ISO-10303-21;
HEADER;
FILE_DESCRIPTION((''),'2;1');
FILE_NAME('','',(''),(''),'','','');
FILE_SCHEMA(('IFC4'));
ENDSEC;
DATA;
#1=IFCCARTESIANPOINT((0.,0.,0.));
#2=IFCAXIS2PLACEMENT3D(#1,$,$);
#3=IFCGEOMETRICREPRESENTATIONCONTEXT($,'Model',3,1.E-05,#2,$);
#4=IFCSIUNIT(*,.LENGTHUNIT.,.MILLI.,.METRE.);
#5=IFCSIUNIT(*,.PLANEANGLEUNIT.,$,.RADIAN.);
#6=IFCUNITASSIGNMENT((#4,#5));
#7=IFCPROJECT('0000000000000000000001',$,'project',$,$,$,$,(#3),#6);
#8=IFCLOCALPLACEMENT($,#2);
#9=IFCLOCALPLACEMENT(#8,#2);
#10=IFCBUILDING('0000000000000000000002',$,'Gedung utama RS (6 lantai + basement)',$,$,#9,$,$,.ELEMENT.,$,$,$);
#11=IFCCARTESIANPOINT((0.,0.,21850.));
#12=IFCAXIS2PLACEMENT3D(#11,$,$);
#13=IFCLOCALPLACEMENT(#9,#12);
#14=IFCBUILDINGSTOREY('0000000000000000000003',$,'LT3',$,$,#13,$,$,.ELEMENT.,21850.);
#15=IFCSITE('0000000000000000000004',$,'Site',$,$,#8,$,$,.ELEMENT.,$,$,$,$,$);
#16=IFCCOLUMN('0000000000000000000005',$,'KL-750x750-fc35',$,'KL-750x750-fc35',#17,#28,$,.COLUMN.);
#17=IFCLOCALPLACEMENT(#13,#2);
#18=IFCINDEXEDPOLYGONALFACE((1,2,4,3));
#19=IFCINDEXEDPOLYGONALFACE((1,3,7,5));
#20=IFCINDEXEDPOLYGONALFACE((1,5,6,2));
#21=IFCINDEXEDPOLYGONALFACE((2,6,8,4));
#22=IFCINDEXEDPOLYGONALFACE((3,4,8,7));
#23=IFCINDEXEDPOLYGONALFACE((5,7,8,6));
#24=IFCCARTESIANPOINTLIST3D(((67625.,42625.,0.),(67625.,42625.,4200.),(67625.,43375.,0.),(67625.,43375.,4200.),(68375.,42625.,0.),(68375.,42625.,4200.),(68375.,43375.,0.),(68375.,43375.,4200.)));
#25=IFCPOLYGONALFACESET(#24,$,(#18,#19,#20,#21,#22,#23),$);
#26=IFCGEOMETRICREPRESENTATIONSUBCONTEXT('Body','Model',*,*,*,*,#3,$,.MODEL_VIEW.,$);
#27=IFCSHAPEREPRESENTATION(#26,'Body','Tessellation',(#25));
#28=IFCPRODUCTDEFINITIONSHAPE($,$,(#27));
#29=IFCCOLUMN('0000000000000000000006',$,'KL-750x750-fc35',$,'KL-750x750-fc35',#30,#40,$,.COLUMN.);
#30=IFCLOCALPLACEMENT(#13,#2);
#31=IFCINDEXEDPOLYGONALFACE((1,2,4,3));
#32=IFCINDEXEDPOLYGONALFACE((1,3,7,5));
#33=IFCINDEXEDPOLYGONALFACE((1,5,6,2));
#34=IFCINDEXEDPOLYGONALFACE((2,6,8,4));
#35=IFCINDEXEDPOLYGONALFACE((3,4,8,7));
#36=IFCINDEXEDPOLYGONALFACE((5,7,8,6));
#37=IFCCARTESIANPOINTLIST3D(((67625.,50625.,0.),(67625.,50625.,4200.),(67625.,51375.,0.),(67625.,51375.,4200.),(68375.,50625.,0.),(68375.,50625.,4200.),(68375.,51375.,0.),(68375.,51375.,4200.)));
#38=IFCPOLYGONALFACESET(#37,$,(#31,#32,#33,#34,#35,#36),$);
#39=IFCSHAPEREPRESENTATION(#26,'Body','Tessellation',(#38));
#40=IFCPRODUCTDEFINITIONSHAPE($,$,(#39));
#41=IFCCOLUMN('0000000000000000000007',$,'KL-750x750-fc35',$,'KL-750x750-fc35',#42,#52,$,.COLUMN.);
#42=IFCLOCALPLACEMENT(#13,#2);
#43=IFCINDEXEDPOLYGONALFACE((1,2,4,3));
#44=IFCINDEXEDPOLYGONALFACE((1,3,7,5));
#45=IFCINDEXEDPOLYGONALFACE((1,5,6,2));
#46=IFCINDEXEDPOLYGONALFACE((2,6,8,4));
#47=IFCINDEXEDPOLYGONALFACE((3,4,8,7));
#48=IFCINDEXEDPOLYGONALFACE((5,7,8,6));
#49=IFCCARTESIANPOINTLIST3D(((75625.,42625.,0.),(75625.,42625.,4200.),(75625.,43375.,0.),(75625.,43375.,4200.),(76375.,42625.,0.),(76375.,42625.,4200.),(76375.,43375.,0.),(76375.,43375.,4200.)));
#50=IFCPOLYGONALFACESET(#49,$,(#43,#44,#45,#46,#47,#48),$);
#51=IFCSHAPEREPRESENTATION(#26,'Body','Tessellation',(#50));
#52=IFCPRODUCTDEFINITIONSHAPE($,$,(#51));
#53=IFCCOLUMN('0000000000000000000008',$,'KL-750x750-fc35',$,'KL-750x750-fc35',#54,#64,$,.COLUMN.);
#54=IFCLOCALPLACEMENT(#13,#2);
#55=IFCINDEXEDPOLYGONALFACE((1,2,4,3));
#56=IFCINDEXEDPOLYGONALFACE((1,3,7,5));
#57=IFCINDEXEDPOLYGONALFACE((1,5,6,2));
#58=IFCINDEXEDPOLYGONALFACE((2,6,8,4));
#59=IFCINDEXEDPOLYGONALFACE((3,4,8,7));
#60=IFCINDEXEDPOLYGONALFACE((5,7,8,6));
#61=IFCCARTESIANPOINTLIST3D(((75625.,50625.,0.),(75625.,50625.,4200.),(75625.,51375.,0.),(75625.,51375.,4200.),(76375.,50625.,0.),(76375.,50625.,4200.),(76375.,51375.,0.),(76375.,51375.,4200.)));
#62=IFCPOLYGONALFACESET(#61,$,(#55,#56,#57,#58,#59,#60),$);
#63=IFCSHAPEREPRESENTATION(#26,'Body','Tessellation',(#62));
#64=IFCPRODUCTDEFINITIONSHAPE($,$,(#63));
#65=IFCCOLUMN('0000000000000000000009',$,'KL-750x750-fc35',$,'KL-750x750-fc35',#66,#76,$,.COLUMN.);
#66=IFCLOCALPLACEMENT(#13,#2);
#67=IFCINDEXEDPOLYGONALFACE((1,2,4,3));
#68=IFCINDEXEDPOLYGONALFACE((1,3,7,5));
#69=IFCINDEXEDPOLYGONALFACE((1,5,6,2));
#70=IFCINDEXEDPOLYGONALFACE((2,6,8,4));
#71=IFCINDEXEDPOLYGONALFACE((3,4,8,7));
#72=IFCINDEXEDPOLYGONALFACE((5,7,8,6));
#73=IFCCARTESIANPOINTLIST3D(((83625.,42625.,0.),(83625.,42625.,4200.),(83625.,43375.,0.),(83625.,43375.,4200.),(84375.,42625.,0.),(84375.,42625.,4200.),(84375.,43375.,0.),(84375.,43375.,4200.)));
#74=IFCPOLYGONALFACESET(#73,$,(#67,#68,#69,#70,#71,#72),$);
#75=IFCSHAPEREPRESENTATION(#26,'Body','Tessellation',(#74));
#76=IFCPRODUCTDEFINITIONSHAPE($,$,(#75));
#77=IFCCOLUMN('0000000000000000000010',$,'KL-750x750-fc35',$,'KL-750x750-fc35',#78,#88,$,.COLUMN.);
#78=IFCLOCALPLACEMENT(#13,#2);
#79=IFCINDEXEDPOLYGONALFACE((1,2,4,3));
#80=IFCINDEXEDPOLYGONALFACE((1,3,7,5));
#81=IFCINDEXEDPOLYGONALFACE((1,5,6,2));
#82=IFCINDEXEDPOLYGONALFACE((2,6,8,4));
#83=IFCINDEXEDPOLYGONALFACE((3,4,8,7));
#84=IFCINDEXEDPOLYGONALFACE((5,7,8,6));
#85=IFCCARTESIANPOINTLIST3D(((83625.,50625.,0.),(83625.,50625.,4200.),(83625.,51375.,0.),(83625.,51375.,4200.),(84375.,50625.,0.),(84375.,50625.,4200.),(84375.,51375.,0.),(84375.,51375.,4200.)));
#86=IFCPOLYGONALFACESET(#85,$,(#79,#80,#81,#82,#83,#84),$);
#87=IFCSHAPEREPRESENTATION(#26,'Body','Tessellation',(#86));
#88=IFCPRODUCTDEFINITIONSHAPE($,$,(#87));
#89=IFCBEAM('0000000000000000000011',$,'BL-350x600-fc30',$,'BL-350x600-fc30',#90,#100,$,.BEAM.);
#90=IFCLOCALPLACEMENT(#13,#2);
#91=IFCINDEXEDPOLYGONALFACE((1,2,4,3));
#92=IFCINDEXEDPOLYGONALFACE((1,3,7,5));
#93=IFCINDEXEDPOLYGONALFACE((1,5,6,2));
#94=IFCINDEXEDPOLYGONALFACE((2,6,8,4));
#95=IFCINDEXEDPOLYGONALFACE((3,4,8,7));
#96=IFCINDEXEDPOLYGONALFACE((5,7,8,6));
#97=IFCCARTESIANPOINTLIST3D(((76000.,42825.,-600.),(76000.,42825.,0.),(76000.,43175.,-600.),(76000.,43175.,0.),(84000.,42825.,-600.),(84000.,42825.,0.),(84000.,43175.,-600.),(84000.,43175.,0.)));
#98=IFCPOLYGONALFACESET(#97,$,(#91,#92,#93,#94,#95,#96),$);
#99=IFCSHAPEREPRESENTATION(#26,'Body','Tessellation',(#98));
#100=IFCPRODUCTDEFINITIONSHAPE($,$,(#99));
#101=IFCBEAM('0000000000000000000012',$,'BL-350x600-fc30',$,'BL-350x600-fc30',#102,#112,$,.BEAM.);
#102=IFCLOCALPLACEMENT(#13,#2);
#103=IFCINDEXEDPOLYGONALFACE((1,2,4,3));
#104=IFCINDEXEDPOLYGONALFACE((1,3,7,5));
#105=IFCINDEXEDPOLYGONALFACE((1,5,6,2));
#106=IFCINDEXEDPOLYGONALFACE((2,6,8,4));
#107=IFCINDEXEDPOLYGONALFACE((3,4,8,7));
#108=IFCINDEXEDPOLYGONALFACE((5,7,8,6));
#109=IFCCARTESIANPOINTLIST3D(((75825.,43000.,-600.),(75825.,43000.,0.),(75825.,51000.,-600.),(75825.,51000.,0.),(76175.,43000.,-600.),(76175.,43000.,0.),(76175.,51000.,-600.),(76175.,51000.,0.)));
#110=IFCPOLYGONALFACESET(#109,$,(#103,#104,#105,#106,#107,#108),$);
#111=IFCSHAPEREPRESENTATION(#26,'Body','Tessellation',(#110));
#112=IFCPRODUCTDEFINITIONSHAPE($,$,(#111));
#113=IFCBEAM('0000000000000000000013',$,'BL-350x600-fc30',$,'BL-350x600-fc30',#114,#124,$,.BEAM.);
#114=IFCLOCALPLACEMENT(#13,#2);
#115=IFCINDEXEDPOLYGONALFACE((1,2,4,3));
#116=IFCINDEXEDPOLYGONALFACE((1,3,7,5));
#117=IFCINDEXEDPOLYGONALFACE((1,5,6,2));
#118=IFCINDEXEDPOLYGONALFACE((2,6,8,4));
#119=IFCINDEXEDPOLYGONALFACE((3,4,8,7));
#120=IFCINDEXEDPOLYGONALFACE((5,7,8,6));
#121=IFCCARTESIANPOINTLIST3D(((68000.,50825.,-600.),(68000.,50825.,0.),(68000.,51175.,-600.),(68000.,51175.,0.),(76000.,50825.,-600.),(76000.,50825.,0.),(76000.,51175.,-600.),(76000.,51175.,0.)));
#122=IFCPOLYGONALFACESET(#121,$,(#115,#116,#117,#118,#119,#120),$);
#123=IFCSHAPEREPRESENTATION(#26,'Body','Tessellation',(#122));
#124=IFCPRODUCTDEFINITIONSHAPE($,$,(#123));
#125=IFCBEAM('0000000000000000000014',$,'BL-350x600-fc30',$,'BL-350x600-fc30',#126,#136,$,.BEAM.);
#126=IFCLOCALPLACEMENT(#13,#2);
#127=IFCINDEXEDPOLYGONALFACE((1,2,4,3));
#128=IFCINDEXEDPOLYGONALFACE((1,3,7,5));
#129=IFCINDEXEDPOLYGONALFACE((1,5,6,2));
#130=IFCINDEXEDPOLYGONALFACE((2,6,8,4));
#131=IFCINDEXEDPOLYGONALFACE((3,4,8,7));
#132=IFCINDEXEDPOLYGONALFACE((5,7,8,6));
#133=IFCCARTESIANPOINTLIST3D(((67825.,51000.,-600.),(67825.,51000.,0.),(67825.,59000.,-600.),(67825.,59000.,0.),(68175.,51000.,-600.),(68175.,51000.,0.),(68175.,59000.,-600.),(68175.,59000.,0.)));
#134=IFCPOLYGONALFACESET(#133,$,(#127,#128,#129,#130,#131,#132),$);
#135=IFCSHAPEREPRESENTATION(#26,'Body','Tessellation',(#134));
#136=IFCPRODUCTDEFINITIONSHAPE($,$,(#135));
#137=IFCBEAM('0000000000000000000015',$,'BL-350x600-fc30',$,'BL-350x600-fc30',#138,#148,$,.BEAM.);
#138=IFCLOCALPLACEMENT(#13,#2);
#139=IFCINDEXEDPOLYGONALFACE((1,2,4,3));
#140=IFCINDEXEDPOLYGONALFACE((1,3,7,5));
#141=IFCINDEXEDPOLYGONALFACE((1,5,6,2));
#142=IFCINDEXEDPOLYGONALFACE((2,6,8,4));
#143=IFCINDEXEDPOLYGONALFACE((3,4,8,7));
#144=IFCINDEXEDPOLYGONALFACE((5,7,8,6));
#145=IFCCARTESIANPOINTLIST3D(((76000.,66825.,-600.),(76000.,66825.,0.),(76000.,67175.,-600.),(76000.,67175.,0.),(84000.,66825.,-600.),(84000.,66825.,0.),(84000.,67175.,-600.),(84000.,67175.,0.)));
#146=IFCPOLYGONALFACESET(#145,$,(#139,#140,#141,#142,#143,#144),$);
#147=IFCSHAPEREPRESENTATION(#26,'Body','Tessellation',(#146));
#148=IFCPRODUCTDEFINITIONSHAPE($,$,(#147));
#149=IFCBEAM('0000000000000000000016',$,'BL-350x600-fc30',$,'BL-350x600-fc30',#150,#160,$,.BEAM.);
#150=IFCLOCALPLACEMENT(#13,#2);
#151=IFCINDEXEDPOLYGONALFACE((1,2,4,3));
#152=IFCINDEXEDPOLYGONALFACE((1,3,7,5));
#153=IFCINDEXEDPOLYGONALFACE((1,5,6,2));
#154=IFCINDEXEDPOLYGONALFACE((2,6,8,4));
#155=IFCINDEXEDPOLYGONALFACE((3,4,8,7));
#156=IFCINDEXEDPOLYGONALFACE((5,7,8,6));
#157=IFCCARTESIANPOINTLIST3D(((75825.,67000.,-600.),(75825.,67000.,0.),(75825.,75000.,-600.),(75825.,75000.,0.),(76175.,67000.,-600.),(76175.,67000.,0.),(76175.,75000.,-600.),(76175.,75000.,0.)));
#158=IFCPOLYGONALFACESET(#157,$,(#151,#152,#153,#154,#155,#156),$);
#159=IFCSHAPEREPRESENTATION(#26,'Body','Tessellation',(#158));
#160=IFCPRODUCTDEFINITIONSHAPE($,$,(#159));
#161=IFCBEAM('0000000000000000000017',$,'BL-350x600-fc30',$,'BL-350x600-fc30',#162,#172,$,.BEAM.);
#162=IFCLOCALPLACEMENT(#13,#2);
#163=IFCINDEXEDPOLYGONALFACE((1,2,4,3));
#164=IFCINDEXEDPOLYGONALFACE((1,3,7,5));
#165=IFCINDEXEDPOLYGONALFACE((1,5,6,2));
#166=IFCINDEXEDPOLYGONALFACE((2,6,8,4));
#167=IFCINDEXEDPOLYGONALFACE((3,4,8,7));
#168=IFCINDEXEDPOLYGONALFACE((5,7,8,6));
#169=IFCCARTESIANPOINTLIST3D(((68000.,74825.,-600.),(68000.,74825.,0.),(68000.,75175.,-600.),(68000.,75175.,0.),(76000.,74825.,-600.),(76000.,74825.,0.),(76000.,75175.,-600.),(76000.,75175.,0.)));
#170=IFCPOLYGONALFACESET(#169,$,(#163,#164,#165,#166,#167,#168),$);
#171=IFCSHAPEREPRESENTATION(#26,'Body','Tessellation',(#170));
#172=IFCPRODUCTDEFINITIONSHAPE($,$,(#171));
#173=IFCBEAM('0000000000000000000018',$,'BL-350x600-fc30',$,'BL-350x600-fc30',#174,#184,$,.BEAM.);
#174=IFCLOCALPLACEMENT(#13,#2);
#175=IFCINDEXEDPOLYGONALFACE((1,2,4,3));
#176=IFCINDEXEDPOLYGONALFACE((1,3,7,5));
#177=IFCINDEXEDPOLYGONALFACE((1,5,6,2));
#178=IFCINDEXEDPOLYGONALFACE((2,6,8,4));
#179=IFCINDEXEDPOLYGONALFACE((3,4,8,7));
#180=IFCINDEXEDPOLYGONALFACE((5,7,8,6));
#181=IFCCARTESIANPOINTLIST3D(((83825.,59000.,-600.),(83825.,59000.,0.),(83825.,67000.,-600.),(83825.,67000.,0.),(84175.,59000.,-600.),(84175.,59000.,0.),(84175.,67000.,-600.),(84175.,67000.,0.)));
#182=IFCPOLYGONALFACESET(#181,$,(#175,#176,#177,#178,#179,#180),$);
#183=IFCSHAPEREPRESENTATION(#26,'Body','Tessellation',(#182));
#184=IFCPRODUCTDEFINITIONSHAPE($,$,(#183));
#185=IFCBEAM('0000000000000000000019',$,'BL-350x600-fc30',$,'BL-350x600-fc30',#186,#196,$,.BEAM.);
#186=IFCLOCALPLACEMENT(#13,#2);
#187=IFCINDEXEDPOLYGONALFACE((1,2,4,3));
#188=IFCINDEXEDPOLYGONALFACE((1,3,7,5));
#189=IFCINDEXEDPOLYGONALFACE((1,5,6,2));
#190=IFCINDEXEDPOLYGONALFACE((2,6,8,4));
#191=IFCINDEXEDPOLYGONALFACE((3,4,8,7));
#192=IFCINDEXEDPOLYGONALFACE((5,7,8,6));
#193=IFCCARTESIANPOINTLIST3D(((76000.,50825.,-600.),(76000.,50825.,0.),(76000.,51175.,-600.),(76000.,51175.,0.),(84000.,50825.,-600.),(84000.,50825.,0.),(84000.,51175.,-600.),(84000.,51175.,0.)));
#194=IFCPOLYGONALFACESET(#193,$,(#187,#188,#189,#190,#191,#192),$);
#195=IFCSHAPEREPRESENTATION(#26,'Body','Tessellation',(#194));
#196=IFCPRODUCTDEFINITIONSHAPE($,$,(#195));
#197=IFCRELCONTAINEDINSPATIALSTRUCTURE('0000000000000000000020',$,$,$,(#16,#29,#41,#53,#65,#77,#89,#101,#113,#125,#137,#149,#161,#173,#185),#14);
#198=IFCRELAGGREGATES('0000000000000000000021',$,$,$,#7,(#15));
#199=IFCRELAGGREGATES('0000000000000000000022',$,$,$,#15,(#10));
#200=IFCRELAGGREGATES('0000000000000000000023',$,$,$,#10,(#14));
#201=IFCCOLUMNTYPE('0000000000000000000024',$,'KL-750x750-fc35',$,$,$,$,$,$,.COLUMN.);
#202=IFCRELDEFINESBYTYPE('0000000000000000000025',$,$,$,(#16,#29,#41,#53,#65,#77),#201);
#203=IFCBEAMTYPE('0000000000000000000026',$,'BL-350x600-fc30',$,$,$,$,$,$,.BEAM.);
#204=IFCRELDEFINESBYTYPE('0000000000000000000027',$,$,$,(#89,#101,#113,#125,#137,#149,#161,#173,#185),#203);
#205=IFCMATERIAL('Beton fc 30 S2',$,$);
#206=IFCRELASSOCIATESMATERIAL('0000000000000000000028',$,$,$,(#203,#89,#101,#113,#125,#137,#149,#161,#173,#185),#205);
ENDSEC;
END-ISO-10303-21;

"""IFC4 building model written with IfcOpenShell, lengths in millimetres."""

from ifc_helpers import new_model, si_unit, frame, origin, origin_2d, place, context, subcontext, project, spatial, rectangle, extrude, material, material_profile, profile_set, profile_usage, type_object, element, save


model = new_model("IFC4")

# Units and contexts
model_context = context("Model", 3, precision=1e-05, world=origin())
body_context = subcontext(model_context, "Body", "Model", "MODEL_VIEW")
ifc_project = project(units=[si_unit("LENGTHUNIT", "METRE", prefix="MILLI"), si_unit("PLANEANGLEUNIT", "RADIAN")], contexts=[model_context])

# Site, building, storey
site_placement = place(None, origin())
site = spatial("IfcSite", under=ifc_project, at=site_placement, Name="Site", CompositionType="ELEMENT")
building_placement = place(site_placement, origin())
building = spatial("IfcBuilding", under=site, at=building_placement, Name="Gedung utama RS (6 lantai + basement)", CompositionType="ELEMENT")
storey_placement = place(building_placement, frame((0.0, 0.0, 21850.0)))
storey = spatial("IfcBuildingStorey", under=building, at=storey_placement, Name="LT3", CompositionType="ELEMENT", Elevation=21850.0)

# Columns
ifc_material_profile_1 = material_profile(None, rectangle(XDim=750.0, YDim=750.0, at=origin_2d()), Name="KL-750x750-fc35")
ifc_profile_set_1 = profile_set([ifc_material_profile_1], Name="KL-750x750-fc35")
ifc_profile_usage_1 = profile_usage(ifc_profile_set_1, cardinal=5)
column_type = type_object("IfcColumnType", Name="KL-750x750-fc35", PredefinedType="COLUMN", material=ifc_profile_set_1)
for number, where, z_axis, x_axis, name in (
    (1, (68000.0, 43000.0, 0.0), (0.0, 0.0, 1.0), (1.0, 0.0, 0.0), "KL-750x750-fc35"),
    (2, (68000.0, 51000.0, 0.0), (0.0, 0.0, 1.0), (1.0, 0.0, 0.0), "KL-750x750-fc35"),
    (3, (76000.0, 43000.0, 0.0), (0.0, 0.0, 1.0), (1.0, 0.0, 0.0), "KL-750x750-fc35"),
    (4, (76000.0, 51000.0, 0.0), (0.0, 0.0, 1.0), (1.0, 0.0, 0.0), "KL-750x750-fc35"),
    (5, (84000.0, 43000.0, 0.0), (0.0, 0.0, 1.0), (1.0, 0.0, 0.0), "KL-750x750-fc35"),
    (6, (84000.0, 51000.0, 0.0), (0.0, 0.0, 1.0), (1.0, 0.0, 0.0), "KL-750x750-fc35"),
):
    element("IfcColumn", number, at=place(storey_placement, frame(where, z_axis=z_axis, x_axis=x_axis)), inside=storey, type_object=column_type, material=ifc_profile_usage_1, Name=name, ObjectType="KL-750x750-fc35", PredefinedType="COLUMN", context=body_context, shape_type="SweptSolid", body=[
        extrude(rectangle(XDim=750.0, YDim=750.0, at=origin_2d()), origin(), (0.0, 0.0, 1.0), 4200.0),
    ])

# Beams
ifc_material = material(Name="Beton fc 30 S2")
ifc_material_profile_2 = material_profile(ifc_material, rectangle(XDim=350.0, YDim=600.0, at=origin_2d()), Name="BL-350x600-fc30")
ifc_profile_set_2 = profile_set([ifc_material_profile_2], Name="BL-350x600-fc30")
ifc_profile_usage_2 = profile_usage(ifc_profile_set_2, cardinal=8)
beam_type_1 = type_object("IfcBeamType", Name="BL-350x600-fc30", PredefinedType="BEAM", material=ifc_profile_set_2)
beam_1_placement = place(storey_placement, frame((76000.0, 43000.0, -300.0)))
element("IfcBeam", 7, at=beam_1_placement, inside=storey, type_object=beam_type_1, material=ifc_profile_usage_2, Name="BL-350x600-fc30", ObjectType="BL-350x600-fc30", PredefinedType="BEAM", context=body_context, shape_type="SweptSolid", body=[
    extrude(rectangle(XDim=350.0, YDim=600.0, at=origin_2d()), frame((0.0, 0.0, 0.0), z_axis=(1.0, 0.0, 0.0), x_axis=(0.0, 1.0, 0.0)), (0.0, 0.0, 1.0), 8000.0),
])
beam_2_placement = place(storey_placement, frame((76000.0, 43000.0, -300.0)))
element("IfcBeam", 8, at=beam_2_placement, inside=storey, type_object=beam_type_1, material=ifc_profile_usage_2, Name="BL-350x600-fc30", ObjectType="BL-350x600-fc30", PredefinedType="BEAM", context=body_context, shape_type="SweptSolid", body=[
    extrude(rectangle(XDim=350.0, YDim=600.0, at=origin_2d()), frame((0.0, 0.0, 0.0), z_axis=(0.0, 1.0, 0.0), x_axis=(-1.0, 0.0, 0.0)), (0.0, 0.0, 1.0), 8000.0),
])
beam_3_placement = place(storey_placement, frame((68000.0, 51000.0, -300.0)))
element("IfcBeam", 9, at=beam_3_placement, inside=storey, type_object=beam_type_1, material=ifc_profile_usage_2, Name="BL-350x600-fc30", ObjectType="BL-350x600-fc30", PredefinedType="BEAM", context=body_context, shape_type="SweptSolid", body=[
    extrude(rectangle(XDim=350.0, YDim=600.0, at=origin_2d()), frame((0.0, 0.0, 0.0), z_axis=(1.0, 0.0, 0.0), x_axis=(0.0, 1.0, 0.0)), (0.0, 0.0, 1.0), 8000.0),
])
beam_4_placement = place(storey_placement, frame((68000.0, 51000.0, -300.0)))
element("IfcBeam", 10, at=beam_4_placement, inside=storey, type_object=beam_type_1, material=ifc_profile_usage_2, Name="BL-350x600-fc30", ObjectType="BL-350x600-fc30", PredefinedType="BEAM", context=body_context, shape_type="SweptSolid", body=[
    extrude(rectangle(XDim=350.0, YDim=600.0, at=origin_2d()), frame((0.0, 0.0, 0.0), z_axis=(0.0, 1.0, 0.0), x_axis=(-1.0, 0.0, 0.0)), (0.0, 0.0, 1.0), 8000.0),
])
beam_5_placement = place(storey_placement, frame((76000.0, 67000.0, -300.0)))
element("IfcBeam", 11, at=beam_5_placement, inside=storey, type_object=beam_type_1, material=ifc_profile_usage_2, Name="BL-350x600-fc30", ObjectType="BL-350x600-fc30", PredefinedType="BEAM", context=body_context, shape_type="SweptSolid", body=[
    extrude(rectangle(XDim=350.0, YDim=600.0, at=origin_2d()), frame((0.0, 0.0, 0.0), z_axis=(1.0, 0.0, 0.0), x_axis=(0.0, 1.0, 0.0)), (0.0, 0.0, 1.0), 8000.0),
])
beam_6_placement = place(storey_placement, frame((76000.0, 67000.0, -300.0)))
element("IfcBeam", 12, at=beam_6_placement, inside=storey, type_object=beam_type_1, material=ifc_profile_usage_2, Name="BL-350x600-fc30", ObjectType="BL-350x600-fc30", PredefinedType="BEAM", context=body_context, shape_type="SweptSolid", body=[
    extrude(rectangle(XDim=350.0, YDim=600.0, at=origin_2d()), frame((0.0, 0.0, 0.0), z_axis=(0.0, 1.0, 0.0), x_axis=(-1.0, 0.0, 0.0)), (0.0, 0.0, 1.0), 8000.0),
])
beam_7_placement = place(storey_placement, frame((68000.0, 75000.0, -300.0)))
element("IfcBeam", 13, at=beam_7_placement, inside=storey, type_object=beam_type_1, material=ifc_profile_usage_2, Name="BL-350x600-fc30", ObjectType="BL-350x600-fc30", PredefinedType="BEAM", context=body_context, shape_type="SweptSolid", body=[
    extrude(rectangle(XDim=350.0, YDim=600.0, at=origin_2d()), frame((0.0, 0.0, 0.0), z_axis=(1.0, 0.0, 0.0), x_axis=(0.0, 1.0, 0.0)), (0.0, 0.0, 1.0), 8000.0),
])
beam_8_placement = place(storey_placement, frame((84000.0, 59000.0, -300.0)))
element("IfcBeam", 14, at=beam_8_placement, inside=storey, type_object=beam_type_1, material=ifc_profile_usage_2, Name="BL-350x600-fc30", ObjectType="BL-350x600-fc30", PredefinedType="BEAM", context=body_context, shape_type="SweptSolid", body=[
    extrude(rectangle(XDim=350.0, YDim=600.0, at=origin_2d()), frame((0.0, 0.0, 0.0), z_axis=(0.0, 1.0, 0.0), x_axis=(-1.0, 0.0, 0.0)), (0.0, 0.0, 1.0), 8000.0),
])
beam_9_placement = place(storey_placement, frame((76000.0, 51000.0, -300.0)))
element("IfcBeam", 15, at=beam_9_placement, inside=storey, type_object=beam_type_1, material=ifc_profile_usage_2, Name="BL-350x600-fc30", ObjectType="BL-350x600-fc30", PredefinedType="BEAM", context=body_context, shape_type="SweptSolid", body=[
    extrude(rectangle(XDim=350.0, YDim=600.0, at=origin_2d()), frame((0.0, 0.0, 0.0), z_axis=(1.0, 0.0, 0.0), x_axis=(0.0, 1.0, 0.0)), (0.0, 0.0, 1.0), 8000.0),
])

save(model, "model.ifc")
